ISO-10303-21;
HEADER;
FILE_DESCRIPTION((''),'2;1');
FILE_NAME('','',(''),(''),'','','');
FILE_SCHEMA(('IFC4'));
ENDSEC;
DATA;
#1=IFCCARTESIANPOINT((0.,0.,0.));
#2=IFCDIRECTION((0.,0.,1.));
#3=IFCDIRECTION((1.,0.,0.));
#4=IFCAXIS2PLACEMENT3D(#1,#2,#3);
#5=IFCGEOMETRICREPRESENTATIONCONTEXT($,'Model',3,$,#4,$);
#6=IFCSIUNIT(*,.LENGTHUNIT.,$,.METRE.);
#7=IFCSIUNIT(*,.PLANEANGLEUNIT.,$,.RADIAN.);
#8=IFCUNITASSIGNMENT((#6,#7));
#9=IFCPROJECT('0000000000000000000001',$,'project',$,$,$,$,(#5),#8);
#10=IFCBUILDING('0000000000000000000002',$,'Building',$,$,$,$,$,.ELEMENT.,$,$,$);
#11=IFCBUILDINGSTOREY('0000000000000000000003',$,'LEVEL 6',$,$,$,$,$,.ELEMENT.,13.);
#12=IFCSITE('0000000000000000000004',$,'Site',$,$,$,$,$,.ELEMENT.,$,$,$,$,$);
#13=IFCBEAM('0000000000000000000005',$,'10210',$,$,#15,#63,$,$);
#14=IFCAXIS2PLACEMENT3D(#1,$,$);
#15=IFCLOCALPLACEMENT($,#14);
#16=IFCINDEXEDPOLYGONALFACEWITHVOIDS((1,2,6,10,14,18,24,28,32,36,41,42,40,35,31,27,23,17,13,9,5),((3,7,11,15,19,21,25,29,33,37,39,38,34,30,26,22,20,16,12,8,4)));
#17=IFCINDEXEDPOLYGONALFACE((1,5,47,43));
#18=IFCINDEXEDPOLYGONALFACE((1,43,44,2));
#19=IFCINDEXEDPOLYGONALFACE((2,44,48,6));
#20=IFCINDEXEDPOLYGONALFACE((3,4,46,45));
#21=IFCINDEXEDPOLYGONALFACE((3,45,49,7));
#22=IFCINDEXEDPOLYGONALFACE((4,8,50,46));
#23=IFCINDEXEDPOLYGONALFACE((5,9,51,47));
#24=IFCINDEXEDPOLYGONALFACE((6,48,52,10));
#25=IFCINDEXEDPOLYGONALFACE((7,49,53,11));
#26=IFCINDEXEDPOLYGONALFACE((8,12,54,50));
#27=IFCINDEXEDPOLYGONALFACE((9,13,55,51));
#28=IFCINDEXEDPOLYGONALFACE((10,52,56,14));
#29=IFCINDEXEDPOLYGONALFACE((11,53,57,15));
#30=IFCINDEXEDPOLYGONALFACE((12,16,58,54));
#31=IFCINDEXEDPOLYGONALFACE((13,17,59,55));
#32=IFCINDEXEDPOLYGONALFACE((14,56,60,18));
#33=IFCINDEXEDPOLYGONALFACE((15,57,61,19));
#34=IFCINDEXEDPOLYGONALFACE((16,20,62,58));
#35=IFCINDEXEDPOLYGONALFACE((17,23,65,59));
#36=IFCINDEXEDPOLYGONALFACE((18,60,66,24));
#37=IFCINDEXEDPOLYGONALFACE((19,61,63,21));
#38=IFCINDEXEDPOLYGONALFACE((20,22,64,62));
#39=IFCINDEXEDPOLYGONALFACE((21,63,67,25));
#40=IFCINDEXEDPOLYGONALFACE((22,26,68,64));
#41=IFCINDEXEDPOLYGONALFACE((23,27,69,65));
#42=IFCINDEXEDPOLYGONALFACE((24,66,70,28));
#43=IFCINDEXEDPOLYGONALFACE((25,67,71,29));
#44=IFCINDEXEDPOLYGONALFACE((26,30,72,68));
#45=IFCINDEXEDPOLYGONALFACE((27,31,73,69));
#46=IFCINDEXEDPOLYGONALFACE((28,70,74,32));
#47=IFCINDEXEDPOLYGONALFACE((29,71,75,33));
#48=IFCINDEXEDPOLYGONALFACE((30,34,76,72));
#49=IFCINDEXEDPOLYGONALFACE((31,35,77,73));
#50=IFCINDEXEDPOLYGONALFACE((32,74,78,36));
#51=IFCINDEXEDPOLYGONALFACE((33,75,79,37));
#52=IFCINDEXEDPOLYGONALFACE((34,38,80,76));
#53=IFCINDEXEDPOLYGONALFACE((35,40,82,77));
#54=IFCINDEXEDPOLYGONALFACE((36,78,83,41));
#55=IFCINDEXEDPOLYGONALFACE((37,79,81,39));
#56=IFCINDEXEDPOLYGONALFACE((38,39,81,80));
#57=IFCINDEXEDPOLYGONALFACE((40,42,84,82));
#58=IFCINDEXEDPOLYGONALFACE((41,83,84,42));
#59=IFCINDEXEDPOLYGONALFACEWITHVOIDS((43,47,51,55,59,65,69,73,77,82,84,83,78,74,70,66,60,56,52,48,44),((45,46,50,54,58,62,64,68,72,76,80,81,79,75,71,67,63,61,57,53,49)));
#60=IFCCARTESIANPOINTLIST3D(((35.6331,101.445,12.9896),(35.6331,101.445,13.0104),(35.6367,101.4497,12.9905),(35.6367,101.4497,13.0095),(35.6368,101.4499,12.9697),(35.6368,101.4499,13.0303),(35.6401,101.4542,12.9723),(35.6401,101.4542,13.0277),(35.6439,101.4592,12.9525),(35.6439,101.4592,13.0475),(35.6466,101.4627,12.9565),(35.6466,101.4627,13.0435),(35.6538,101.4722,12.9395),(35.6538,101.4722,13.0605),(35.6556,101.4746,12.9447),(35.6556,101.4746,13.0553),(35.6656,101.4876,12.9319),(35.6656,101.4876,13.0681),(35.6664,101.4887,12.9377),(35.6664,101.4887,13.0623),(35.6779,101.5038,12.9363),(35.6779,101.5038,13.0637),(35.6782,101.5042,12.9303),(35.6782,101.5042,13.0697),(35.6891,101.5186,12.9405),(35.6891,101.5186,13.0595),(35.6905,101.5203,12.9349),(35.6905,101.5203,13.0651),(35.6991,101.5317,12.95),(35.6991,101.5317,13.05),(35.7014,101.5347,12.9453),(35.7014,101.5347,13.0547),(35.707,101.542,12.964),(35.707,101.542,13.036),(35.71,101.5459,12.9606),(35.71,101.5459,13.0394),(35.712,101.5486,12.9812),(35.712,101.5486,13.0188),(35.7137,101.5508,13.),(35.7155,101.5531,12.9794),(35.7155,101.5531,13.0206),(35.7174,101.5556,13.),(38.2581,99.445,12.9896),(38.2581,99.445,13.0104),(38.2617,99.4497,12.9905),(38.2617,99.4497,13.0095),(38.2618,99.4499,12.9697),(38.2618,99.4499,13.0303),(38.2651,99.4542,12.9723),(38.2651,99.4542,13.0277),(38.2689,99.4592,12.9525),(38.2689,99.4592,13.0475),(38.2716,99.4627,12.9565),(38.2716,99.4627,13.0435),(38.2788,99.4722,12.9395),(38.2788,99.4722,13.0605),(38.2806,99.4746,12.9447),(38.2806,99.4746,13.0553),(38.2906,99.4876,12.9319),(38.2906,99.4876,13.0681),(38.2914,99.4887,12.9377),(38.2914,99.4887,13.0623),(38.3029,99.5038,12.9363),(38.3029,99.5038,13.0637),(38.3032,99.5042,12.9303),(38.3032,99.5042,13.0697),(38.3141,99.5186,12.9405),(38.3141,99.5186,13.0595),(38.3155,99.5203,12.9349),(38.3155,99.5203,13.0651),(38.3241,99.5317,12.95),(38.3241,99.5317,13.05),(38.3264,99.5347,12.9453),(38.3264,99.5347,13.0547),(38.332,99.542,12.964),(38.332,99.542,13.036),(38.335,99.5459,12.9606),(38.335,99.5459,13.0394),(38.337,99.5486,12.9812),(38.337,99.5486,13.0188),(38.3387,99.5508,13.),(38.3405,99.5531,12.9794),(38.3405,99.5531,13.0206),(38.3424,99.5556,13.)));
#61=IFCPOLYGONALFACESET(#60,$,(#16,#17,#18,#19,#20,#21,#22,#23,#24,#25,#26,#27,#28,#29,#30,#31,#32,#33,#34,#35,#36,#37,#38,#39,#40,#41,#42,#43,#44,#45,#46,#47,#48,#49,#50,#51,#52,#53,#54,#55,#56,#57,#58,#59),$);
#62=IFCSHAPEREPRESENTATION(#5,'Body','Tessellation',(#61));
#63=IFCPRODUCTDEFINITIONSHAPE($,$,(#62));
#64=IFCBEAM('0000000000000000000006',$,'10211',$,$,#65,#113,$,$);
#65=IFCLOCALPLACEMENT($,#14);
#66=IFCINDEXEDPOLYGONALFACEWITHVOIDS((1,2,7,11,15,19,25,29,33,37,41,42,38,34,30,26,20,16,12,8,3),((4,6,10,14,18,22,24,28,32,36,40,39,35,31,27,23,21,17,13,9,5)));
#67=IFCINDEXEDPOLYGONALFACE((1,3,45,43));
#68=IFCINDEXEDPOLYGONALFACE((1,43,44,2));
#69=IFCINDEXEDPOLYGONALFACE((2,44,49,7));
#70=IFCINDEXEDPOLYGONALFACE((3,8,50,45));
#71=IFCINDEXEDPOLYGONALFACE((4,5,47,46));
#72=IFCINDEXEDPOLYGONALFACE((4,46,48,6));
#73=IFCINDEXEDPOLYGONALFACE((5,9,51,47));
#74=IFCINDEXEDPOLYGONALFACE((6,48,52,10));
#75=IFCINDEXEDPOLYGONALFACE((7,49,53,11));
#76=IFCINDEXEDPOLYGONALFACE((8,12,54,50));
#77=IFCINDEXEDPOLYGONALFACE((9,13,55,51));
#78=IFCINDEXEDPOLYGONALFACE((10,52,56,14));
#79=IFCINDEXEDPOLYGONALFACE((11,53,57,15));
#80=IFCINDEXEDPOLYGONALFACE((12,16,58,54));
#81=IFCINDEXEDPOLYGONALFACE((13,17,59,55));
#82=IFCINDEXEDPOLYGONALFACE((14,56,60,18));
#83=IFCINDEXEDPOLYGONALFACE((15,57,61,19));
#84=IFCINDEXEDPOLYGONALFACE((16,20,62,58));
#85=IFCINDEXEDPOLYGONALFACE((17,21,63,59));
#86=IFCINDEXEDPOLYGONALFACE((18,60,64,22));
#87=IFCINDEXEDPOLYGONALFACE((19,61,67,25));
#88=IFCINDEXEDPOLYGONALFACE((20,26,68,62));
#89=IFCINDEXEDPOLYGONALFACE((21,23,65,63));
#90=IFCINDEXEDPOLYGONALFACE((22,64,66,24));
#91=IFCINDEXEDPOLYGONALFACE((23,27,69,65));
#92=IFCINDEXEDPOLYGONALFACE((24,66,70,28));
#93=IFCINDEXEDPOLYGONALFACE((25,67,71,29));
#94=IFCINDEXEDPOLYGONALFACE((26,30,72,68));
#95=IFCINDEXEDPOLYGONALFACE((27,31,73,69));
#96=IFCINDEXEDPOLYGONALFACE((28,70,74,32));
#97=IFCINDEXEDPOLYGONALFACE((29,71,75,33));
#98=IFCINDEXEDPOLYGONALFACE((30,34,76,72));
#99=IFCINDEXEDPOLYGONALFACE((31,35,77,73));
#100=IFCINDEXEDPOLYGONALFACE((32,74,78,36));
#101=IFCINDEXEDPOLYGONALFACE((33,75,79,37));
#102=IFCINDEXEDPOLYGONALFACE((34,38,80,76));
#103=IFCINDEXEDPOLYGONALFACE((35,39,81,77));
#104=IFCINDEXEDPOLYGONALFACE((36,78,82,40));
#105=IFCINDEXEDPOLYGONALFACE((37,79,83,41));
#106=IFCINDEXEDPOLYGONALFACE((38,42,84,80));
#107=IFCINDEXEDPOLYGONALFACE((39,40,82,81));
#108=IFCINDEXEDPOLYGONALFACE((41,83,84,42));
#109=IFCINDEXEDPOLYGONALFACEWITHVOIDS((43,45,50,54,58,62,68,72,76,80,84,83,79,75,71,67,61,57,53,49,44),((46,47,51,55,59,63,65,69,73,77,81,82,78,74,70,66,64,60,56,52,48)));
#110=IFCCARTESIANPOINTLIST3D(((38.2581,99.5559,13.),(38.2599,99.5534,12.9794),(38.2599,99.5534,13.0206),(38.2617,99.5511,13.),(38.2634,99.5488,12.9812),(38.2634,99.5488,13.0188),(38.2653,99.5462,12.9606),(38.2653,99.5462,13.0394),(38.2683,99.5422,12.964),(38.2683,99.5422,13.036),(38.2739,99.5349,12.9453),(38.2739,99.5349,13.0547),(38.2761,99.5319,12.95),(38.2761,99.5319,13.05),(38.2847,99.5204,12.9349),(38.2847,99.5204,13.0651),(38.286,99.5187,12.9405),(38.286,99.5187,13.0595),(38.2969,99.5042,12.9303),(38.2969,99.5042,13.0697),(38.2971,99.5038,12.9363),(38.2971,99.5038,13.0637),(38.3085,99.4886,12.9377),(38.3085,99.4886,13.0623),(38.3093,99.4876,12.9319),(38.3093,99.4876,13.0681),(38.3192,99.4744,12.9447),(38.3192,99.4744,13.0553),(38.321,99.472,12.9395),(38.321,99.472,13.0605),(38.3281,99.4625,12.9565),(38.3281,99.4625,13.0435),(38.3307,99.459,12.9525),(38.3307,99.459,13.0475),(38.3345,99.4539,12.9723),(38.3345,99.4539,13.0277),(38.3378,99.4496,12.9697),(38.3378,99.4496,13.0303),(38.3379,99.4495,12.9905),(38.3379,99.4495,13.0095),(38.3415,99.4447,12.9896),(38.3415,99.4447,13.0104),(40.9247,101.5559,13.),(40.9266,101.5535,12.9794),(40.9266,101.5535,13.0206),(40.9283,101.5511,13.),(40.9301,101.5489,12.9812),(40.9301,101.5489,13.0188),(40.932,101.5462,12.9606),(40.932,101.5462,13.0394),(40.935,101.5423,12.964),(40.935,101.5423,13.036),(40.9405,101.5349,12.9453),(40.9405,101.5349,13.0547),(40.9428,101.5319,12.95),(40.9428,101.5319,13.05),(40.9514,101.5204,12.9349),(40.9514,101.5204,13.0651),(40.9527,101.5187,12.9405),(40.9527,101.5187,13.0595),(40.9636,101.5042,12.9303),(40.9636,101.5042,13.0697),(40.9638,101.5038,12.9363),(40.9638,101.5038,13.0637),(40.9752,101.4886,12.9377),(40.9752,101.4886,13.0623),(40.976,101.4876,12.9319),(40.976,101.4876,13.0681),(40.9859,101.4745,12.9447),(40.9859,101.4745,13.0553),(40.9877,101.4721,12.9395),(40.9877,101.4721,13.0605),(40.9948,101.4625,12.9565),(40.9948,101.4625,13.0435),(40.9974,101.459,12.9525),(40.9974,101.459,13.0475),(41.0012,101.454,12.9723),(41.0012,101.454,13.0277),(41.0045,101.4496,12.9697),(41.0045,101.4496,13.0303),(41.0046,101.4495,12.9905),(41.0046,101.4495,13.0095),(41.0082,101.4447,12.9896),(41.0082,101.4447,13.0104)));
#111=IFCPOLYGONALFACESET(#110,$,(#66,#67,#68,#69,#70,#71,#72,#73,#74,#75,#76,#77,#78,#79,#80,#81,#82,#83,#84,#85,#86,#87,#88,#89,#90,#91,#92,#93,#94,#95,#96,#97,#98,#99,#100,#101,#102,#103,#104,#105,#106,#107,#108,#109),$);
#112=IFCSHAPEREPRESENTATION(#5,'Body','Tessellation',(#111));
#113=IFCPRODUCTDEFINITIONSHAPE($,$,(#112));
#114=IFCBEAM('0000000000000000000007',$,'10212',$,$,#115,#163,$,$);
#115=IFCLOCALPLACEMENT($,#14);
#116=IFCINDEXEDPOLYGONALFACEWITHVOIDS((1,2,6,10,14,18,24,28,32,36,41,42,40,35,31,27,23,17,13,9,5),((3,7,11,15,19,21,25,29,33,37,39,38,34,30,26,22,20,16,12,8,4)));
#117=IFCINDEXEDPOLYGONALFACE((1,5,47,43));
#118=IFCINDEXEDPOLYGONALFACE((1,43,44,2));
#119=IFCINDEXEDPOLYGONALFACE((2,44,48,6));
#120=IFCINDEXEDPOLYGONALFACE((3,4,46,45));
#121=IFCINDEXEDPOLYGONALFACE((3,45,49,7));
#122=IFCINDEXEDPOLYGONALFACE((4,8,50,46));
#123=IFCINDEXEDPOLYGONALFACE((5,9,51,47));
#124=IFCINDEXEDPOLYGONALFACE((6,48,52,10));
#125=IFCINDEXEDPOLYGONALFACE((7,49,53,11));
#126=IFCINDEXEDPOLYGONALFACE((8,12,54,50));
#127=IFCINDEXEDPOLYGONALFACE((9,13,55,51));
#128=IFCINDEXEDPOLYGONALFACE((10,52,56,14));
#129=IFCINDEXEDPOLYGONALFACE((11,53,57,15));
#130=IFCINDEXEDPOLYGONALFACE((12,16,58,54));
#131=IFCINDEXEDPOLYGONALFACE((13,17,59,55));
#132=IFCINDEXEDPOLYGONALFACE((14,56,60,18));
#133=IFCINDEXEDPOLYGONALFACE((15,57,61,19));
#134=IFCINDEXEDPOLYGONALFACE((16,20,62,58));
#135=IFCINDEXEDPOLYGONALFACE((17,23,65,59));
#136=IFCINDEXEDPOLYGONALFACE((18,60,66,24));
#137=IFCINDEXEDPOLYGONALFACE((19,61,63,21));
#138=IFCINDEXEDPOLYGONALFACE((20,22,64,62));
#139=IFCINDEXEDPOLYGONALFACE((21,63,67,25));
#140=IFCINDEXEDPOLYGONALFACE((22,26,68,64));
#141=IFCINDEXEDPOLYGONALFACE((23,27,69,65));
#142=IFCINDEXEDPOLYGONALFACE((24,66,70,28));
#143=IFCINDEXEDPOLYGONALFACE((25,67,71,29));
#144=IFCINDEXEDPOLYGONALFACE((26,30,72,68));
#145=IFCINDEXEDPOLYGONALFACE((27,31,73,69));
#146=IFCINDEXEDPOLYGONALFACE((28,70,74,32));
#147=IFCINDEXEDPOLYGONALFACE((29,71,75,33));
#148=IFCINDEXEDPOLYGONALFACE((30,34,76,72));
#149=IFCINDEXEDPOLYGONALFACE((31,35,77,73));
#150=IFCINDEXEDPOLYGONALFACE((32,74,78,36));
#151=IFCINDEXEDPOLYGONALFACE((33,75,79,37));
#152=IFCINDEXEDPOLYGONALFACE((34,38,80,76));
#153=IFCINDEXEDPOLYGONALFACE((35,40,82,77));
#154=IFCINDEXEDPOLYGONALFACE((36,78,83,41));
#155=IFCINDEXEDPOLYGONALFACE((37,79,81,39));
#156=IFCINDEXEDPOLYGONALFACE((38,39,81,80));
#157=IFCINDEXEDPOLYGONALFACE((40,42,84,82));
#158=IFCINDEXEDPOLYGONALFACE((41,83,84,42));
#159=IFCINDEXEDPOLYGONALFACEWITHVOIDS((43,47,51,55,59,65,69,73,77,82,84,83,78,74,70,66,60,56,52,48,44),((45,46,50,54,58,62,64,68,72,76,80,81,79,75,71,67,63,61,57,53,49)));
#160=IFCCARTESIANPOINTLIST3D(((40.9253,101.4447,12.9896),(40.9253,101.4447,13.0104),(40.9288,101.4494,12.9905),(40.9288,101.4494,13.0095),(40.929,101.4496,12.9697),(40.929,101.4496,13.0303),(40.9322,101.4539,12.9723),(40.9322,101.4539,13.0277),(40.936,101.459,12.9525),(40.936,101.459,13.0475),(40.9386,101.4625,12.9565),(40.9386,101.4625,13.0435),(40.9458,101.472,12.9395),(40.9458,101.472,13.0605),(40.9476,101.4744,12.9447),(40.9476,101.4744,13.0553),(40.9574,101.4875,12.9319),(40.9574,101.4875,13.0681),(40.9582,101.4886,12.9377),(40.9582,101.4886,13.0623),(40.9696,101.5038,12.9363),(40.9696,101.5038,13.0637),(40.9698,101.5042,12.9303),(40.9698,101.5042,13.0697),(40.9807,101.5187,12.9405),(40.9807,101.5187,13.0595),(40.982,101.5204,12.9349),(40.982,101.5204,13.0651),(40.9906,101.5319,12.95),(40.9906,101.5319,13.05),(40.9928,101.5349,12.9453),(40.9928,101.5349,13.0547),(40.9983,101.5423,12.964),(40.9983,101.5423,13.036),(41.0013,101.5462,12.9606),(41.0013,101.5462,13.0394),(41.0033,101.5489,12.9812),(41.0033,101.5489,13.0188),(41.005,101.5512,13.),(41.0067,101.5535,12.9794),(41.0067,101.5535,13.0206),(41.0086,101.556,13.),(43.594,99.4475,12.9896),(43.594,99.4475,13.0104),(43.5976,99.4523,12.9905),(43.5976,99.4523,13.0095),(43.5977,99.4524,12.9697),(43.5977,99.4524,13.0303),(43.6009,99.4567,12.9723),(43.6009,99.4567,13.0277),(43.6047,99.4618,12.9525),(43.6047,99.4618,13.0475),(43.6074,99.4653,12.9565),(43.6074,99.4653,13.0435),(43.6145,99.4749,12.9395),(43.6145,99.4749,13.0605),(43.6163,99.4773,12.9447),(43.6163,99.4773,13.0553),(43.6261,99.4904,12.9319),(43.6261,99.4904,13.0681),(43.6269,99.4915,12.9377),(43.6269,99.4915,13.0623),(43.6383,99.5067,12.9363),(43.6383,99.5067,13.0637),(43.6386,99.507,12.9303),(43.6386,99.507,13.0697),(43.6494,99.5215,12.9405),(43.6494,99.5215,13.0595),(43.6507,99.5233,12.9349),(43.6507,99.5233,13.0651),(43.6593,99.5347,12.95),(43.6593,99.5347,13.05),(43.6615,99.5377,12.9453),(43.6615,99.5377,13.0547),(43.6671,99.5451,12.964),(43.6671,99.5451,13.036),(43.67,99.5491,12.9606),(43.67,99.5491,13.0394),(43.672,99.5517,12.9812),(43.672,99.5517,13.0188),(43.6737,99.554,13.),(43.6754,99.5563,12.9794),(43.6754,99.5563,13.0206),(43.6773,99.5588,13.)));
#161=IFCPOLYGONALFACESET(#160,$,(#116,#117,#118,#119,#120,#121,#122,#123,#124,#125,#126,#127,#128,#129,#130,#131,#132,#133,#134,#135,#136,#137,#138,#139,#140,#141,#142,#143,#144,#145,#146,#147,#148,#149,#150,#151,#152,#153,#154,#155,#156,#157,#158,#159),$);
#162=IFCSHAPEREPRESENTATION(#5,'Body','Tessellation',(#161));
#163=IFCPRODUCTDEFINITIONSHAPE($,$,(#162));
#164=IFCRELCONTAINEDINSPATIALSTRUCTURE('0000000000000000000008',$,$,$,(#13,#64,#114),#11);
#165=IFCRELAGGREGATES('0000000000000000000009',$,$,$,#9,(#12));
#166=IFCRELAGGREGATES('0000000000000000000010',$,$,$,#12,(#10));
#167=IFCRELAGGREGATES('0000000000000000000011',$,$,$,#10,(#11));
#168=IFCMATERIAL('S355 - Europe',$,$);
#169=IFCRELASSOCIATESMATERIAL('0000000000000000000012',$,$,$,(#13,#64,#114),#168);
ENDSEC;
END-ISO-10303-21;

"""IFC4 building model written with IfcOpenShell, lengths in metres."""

from ifc_helpers import new_model, si_unit, frame, origin_with_axes, origin_2d_with_axis, place, context, project, spatial, hollow_circle, extrude, material, material_profile, profile_set, profile_usage, element, save


model = new_model("IFC4")

# Units and contexts
model_context = context("Model", 3, world=origin_with_axes())
ifc_project = project(units=[si_unit("LENGTHUNIT", "METRE"), si_unit("PLANEANGLEUNIT", "RADIAN")], contexts=[model_context])

# Site, building, storey
site = spatial("IfcSite", under=ifc_project, Name="Site", CompositionType="ELEMENT")
building = spatial("IfcBuilding", under=site, Name="Building", CompositionType="ELEMENT")
storey = spatial("IfcBuildingStorey", under=building, Name="LEVEL 6", CompositionType="ELEMENT", Elevation=13.0)

# Shared definitions
ifc_material = material(Name="S355 - Europe")

# Beams
ifc_material_profile_1 = material_profile(ifc_material, hollow_circle(Radius=0.0699, WallThickness=0.006, at=origin_2d_with_axis()))
ifc_profile_set_1 = profile_set([ifc_material_profile_1])
ifc_profile_usage_1 = profile_usage(ifc_profile_set_1, cardinal=10)
beam_1_placement = place(None, frame((35.675, 101.5, 13.0), z_axis=(0.795432, -0.606043, 0.0), x_axis=(0.606043, 0.795432, 0.0)))
element("IfcBeam", 1, at=beam_1_placement, inside=storey, material=ifc_profile_usage_1, Name="10210", context=model_context, shape_type="SweptSolid", body=[
    extrude(hollow_circle(Radius=0.0699, WallThickness=0.006, at=origin_2d_with_axis()), origin_with_axes(), (0.0, 0.0, 1.0), 3.3001),
])
ifc_material_profile_2 = material_profile(ifc_material, hollow_circle(Radius=0.0699, WallThickness=0.006, at=origin_2d_with_axis()))
ifc_profile_set_2 = profile_set([ifc_material_profile_2])
ifc_profile_usage_2 = profile_usage(ifc_profile_set_2, cardinal=10)
beam_2_placement = place(None, frame((38.3, 99.5, 13.0), z_axis=(0.8, 0.6, 0.0), x_axis=(-0.59969, 0.800232, 0.0)))
element("IfcBeam", 2, at=beam_2_placement, inside=storey, material=ifc_profile_usage_2, Name="10211", context=model_context, shape_type="SweptSolid", body=[
    extrude(hollow_circle(Radius=0.0699, WallThickness=0.006, at=origin_2d_with_axis()), origin_with_axes(), (0.0, 0.0, 1.0), 3.3334),
])
ifc_material_profile_3 = material_profile(ifc_material, hollow_circle(Radius=0.0699, WallThickness=0.006, at=origin_2d_with_axis()))
ifc_profile_set_3 = profile_set([ifc_material_profile_3])
ifc_profile_usage_3 = profile_usage(ifc_profile_set_3, cardinal=10)
beam_3_placement = place(None, frame((40.9667, 101.5, 13.0), z_axis=(0.800631, -0.599157, 0.0), x_axis=(0.599157, 0.800631, 0.0)))
element("IfcBeam", 3, at=beam_3_placement, inside=storey, material=ifc_profile_usage_3, Name="10212", context=model_context, shape_type="SweptSolid", body=[
    extrude(hollow_circle(Radius=0.0699, WallThickness=0.006, at=origin_2d_with_axis()), origin_with_axes(), (0.0, 0.0, 1.0), 3.3333),
])

save(model, "model.ifc")
